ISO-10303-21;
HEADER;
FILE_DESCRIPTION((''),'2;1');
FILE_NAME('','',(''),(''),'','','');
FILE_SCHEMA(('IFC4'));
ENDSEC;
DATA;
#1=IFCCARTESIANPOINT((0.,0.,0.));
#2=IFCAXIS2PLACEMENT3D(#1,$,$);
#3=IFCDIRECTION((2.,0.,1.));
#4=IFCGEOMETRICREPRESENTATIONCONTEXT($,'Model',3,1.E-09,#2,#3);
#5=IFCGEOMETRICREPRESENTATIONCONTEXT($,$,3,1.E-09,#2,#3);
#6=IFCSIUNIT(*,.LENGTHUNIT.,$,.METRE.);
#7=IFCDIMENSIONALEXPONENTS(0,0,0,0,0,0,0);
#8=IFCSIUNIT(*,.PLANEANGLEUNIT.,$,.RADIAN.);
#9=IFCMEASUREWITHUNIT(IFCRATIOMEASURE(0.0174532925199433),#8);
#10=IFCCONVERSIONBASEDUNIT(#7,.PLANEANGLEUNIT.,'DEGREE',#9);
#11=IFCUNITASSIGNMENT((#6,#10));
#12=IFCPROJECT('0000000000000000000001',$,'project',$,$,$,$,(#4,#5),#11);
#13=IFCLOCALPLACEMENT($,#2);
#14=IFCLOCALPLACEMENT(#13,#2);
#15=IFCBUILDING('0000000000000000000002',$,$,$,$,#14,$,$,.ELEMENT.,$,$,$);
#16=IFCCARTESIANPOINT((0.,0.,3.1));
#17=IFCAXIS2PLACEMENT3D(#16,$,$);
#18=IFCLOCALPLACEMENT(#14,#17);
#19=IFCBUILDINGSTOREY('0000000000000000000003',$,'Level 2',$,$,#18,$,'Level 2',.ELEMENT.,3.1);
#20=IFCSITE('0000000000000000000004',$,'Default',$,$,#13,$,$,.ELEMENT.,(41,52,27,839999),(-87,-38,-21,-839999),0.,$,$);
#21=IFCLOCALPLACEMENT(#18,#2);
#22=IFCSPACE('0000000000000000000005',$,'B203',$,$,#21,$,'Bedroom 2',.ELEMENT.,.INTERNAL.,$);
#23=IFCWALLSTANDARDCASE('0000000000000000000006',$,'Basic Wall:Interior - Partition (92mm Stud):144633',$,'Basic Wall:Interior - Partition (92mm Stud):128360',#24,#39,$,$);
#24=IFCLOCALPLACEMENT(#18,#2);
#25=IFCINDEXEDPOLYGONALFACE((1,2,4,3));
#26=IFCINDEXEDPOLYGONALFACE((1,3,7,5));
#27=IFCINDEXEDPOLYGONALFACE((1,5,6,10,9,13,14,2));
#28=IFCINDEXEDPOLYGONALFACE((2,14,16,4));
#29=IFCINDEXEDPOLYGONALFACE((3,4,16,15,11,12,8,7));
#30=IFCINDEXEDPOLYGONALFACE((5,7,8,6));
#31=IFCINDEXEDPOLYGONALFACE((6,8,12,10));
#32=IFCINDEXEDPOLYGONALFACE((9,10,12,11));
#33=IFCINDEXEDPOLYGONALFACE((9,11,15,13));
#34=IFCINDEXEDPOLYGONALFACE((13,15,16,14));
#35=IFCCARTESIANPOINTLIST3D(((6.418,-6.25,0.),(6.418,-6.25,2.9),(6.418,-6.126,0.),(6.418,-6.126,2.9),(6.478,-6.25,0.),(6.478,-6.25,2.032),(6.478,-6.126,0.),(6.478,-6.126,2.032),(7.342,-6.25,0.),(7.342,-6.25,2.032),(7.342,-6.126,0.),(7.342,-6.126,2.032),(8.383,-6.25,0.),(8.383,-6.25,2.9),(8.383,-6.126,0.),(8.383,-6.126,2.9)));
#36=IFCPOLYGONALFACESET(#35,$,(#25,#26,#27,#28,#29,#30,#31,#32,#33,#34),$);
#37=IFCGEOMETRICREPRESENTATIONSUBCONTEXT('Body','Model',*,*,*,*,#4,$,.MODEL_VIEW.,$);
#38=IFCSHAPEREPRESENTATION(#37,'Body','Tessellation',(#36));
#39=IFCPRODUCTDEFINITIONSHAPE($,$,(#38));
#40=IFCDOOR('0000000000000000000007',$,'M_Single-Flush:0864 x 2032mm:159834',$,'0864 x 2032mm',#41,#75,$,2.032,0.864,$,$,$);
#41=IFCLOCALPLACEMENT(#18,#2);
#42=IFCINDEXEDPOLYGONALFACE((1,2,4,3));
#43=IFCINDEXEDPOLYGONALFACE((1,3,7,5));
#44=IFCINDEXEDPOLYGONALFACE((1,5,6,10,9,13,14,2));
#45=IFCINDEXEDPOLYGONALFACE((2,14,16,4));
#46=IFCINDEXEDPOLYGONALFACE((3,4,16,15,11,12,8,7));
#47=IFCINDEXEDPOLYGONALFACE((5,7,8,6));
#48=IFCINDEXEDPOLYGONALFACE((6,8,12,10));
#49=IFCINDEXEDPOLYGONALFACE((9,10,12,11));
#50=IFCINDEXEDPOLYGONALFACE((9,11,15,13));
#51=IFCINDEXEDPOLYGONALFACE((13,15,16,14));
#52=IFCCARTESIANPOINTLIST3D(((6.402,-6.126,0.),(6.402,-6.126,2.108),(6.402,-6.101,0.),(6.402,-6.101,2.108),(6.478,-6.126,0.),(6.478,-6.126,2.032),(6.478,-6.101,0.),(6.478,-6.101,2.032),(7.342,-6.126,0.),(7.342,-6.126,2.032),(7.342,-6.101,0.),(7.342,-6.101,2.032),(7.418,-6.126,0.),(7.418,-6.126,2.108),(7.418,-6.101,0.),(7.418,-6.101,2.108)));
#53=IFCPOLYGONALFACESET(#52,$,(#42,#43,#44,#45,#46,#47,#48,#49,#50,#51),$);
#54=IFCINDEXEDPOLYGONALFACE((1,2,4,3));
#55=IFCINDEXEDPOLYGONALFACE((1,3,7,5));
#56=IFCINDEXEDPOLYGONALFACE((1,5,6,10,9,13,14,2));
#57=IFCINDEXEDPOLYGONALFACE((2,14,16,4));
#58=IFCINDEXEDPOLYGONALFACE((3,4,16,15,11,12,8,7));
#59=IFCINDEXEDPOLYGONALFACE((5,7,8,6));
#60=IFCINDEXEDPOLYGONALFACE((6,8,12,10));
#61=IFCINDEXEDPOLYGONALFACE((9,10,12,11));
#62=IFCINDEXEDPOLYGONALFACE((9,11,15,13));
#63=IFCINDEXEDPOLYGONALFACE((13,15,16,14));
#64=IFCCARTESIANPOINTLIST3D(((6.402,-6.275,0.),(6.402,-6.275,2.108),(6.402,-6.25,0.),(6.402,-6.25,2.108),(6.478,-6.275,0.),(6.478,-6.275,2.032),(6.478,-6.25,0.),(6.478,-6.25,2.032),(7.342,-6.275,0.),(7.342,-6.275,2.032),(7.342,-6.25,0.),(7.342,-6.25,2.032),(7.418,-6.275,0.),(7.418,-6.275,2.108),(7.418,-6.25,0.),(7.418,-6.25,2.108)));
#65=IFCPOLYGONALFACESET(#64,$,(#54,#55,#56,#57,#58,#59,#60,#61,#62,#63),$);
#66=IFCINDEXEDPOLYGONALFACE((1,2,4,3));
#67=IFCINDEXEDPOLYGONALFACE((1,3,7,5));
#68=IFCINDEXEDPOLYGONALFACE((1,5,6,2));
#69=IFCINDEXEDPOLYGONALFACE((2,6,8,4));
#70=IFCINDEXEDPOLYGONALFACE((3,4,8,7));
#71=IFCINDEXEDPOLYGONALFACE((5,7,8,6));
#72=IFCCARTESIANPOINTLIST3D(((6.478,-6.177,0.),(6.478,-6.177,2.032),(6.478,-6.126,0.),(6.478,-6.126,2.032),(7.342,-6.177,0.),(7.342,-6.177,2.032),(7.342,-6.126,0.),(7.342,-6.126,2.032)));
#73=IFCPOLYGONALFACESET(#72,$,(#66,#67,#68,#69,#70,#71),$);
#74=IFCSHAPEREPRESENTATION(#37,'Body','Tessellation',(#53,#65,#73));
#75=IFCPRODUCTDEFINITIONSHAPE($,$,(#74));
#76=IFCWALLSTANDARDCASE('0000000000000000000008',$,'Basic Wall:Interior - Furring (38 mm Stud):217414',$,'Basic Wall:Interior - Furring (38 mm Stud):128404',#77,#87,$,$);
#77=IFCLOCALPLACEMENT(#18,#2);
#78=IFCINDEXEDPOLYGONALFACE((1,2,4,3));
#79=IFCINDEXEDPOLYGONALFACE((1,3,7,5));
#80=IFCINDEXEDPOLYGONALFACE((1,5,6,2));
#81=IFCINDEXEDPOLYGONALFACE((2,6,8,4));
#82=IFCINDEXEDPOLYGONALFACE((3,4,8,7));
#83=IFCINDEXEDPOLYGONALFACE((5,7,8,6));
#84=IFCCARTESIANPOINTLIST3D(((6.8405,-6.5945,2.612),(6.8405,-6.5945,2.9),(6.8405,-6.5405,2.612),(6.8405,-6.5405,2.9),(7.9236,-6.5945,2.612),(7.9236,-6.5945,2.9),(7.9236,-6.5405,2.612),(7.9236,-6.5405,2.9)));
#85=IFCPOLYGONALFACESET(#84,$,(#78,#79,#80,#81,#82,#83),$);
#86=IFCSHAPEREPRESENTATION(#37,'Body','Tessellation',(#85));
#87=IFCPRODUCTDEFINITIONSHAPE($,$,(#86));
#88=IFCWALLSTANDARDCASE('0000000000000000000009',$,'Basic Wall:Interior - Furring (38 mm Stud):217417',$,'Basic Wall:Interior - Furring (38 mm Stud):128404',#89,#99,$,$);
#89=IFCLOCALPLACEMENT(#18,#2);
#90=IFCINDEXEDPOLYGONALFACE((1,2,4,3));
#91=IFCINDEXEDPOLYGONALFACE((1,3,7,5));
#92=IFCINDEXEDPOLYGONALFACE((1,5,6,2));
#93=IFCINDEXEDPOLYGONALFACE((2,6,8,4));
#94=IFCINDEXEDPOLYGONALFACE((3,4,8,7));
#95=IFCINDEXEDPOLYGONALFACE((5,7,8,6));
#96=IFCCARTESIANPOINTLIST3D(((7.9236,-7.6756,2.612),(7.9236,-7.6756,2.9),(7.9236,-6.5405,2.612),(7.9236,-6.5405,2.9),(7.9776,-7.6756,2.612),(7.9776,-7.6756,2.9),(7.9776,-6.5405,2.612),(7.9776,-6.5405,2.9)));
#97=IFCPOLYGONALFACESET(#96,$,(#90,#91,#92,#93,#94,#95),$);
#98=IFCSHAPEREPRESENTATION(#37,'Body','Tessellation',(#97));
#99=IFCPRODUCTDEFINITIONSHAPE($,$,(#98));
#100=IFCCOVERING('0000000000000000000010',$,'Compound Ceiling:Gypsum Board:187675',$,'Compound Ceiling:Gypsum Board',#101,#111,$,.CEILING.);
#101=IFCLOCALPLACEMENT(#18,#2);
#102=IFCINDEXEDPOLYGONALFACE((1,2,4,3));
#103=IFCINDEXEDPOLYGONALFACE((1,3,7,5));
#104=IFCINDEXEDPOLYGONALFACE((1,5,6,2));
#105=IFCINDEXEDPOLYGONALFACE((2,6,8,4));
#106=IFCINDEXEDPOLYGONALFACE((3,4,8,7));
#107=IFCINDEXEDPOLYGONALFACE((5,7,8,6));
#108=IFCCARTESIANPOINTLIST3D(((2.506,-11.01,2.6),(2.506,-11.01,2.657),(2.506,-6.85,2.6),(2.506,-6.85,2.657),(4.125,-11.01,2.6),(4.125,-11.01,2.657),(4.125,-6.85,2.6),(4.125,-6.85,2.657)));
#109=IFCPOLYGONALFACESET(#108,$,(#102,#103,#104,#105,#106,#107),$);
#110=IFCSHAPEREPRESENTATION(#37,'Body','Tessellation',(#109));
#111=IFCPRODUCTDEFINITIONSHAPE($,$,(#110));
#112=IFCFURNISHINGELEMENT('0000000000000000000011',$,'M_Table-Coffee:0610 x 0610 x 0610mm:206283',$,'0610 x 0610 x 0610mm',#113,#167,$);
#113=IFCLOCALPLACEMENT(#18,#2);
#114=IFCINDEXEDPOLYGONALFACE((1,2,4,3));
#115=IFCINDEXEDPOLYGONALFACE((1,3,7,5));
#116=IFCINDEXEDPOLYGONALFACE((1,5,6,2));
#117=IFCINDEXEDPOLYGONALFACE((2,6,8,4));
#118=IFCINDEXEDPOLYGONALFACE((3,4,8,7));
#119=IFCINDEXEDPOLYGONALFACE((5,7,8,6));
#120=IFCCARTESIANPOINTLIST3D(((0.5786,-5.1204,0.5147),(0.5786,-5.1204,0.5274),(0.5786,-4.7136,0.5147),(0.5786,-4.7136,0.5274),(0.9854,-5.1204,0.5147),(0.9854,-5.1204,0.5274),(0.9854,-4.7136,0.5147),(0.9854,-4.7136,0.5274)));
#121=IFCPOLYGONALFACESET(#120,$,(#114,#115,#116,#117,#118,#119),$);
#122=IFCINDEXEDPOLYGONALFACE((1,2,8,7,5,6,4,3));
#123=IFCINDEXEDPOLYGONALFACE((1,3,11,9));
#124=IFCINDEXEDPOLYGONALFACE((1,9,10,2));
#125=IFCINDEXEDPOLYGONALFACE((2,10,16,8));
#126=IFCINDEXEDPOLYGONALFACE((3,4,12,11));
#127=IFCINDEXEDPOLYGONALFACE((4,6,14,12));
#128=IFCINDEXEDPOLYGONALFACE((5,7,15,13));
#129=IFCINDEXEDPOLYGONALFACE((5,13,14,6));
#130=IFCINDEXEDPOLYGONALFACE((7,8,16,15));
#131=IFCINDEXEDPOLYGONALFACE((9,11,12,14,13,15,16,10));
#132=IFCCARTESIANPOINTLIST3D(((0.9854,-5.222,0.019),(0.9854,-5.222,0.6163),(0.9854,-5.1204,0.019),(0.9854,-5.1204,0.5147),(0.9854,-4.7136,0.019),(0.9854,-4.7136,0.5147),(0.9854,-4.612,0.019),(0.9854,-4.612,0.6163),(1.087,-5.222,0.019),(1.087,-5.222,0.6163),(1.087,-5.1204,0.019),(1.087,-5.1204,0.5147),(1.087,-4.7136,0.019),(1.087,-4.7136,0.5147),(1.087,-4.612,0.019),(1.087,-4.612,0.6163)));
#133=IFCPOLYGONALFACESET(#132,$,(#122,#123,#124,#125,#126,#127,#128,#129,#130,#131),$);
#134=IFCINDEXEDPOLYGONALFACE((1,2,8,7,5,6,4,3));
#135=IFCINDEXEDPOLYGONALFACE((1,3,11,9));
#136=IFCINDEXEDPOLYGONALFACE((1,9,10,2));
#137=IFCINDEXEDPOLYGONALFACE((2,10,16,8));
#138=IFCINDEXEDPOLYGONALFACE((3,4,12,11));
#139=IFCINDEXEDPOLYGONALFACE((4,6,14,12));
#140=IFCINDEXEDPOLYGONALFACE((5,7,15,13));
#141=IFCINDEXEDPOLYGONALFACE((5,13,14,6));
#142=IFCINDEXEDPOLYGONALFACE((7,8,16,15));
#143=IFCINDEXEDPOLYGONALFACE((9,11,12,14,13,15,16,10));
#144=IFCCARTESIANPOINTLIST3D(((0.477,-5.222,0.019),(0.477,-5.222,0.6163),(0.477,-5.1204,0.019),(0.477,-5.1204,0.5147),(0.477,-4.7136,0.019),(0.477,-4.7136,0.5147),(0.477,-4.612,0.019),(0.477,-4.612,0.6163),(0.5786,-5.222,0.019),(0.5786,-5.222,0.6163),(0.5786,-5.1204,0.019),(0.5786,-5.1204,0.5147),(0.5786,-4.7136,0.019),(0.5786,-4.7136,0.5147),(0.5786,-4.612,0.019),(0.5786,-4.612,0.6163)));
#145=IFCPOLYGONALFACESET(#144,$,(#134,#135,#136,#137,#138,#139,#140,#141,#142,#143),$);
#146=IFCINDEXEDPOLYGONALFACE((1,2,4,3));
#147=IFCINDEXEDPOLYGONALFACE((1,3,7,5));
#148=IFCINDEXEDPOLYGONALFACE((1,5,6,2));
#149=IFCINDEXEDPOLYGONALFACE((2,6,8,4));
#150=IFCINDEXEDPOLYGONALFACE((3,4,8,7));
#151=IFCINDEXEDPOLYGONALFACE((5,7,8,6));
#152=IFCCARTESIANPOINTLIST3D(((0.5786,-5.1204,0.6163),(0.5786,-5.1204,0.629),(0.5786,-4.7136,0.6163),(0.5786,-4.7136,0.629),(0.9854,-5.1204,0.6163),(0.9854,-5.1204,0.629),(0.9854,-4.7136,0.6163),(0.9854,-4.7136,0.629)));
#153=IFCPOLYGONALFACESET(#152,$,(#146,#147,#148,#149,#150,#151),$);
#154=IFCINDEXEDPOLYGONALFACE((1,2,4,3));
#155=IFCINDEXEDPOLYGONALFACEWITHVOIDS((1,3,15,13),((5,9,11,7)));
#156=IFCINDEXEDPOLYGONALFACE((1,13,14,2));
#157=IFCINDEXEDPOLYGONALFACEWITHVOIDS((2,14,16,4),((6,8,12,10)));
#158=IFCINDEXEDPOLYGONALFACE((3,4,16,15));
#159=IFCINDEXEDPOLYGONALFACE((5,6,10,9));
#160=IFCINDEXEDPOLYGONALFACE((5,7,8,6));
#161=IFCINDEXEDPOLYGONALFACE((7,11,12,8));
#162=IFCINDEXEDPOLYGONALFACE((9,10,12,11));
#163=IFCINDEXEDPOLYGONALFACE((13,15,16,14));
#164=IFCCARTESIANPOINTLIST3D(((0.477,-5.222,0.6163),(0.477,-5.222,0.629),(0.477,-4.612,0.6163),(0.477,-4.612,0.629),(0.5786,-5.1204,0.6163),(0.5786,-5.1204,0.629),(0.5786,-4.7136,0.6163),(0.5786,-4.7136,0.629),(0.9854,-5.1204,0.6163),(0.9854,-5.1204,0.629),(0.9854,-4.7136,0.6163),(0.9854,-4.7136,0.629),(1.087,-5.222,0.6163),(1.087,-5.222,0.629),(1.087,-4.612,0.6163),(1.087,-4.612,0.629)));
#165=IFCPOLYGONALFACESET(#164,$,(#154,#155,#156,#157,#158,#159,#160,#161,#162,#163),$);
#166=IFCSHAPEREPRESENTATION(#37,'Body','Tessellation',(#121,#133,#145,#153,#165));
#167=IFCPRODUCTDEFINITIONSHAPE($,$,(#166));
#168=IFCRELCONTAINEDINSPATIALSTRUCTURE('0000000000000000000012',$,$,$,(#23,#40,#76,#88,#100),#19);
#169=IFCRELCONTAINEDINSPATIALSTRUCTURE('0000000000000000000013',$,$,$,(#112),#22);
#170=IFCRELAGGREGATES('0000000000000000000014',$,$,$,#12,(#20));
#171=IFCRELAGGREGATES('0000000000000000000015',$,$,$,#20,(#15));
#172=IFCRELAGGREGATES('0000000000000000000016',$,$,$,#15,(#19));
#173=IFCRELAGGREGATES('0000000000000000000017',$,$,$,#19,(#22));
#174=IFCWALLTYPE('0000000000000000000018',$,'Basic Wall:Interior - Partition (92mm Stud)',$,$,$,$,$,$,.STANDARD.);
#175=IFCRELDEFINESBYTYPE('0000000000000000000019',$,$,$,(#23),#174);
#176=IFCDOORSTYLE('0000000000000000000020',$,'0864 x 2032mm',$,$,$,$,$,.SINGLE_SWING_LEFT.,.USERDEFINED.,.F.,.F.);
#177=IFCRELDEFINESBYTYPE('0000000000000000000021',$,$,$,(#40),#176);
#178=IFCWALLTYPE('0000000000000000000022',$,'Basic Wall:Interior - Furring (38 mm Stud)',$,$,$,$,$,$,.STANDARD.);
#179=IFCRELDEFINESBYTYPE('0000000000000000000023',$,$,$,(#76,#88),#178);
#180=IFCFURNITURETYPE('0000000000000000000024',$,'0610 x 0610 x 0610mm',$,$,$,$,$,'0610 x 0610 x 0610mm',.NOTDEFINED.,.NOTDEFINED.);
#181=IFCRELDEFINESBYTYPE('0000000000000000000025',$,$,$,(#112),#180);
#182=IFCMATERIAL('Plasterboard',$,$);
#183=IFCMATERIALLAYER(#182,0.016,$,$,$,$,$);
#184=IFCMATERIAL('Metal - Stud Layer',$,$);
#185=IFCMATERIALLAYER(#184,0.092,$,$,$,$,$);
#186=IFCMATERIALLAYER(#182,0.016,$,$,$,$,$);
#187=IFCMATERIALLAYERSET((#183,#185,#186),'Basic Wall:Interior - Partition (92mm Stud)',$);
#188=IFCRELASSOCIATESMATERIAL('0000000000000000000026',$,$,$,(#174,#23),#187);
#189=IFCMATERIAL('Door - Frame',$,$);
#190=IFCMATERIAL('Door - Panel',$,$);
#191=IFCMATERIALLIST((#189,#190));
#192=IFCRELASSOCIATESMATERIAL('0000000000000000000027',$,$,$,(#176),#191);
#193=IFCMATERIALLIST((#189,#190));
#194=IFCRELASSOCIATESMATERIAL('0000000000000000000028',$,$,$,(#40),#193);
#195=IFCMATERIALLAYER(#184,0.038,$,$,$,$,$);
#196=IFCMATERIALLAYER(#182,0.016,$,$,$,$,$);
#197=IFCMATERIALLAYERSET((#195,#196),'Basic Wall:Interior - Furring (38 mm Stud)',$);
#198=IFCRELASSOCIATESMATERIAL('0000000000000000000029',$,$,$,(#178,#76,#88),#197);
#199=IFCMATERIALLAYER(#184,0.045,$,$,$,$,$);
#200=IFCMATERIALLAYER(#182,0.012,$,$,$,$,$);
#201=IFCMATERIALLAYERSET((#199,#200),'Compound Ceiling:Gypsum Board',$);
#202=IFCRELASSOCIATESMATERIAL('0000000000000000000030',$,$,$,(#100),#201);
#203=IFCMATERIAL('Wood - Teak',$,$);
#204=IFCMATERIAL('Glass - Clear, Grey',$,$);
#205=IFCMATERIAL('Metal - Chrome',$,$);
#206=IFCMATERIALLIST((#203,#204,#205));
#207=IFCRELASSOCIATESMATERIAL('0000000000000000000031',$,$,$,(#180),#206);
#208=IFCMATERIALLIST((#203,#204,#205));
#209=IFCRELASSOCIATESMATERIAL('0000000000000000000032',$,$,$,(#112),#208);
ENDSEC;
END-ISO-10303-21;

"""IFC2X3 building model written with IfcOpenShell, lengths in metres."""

from ifc_helpers import new_model, entity, si_unit, converted_unit, direction, frame, frame_2d, origin, origin_2d_with_axis, place, context, subcontext, project, spatial, polyline, rectangle, outline, extrude, source, transform, mapped, material, material_list, layer, layer_set, layer_usage, type_object, type_shapes, element, fill, save


model = new_model("IFC2X3")

# Units and contexts
model_context = context("Model", 3, precision=1e-09, world=origin(), true_north=direction((2.0, 0.0, 1.0)))
context_of_model = context(None, 3, precision=1e-09, world=origin(), true_north=direction((2.0, 0.0, 1.0)))
body_context = subcontext(model_context, "Body", "Model", "MODEL_VIEW")
ifc_project = project(units=[si_unit("LENGTHUNIT", "METRE"), converted_unit("PLANEANGLEUNIT", "DEGREE", entity("IfcRatioMeasure", 0.0174532925199433), si_unit("PLANEANGLEUNIT", "RADIAN"), dimensions=[0, 0, 0, 0, 0, 0, 0])], contexts=[model_context, context_of_model])

# Site, building, storey
site_placement = place(None, origin())
site = spatial("IfcSite", under=ifc_project, at=site_placement, Name="Default", CompositionType="ELEMENT", RefLatitude=(41, 52, 27, 839999), RefLongitude=(-87, -38, -21, -839999), RefElevation=0.0)
building_placement = place(site_placement, origin())
building = spatial("IfcBuilding", under=site, at=building_placement, CompositionType="ELEMENT")
storey_placement = place(building_placement, frame((0.0, 0.0, 3.1)))
storey = spatial("IfcBuildingStorey", under=building, at=storey_placement, Name="Level 2", LongName="Level 2", CompositionType="ELEMENT", Elevation=3.1)

# Shared definitions
ifc_material_1 = material(Name="Metal - Stud Layer")
ifc_material_2 = material(Name="Plasterboard")

# Wall, opening, door
ifc_layer_1 = layer(ifc_material_2, 0.016)
ifc_layer_2 = layer(ifc_material_1, 0.092)
ifc_layer_3 = layer(ifc_material_2, 0.016)
ifc_layer_set_1 = layer_set([ifc_layer_1, ifc_layer_2, ifc_layer_3], Name="Basic Wall:Interior - Partition (92mm Stud)")
wall_type_1 = type_object("IfcWallType", Name="Basic Wall:Interior - Partition (92mm Stud)", PredefinedType="STANDARD", material=ifc_layer_set_1)
ifc_material_3 = material(Name="Door - Frame")
ifc_material_4 = material(Name="Door - Panel")
ifc_layer_usage_1 = layer_usage(ifc_layer_set_1, "AXIS2", "NEGATIVE", 0.062)
wall_1_placement = place(storey_placement, frame((6.418, -6.188, 0.0)))
wall_1 = element("IfcWallStandardCase", 1, at=wall_1_placement, inside=storey, type_object=wall_type_1, material=ifc_layer_usage_1, Name="Basic Wall:Interior - Partition (92mm Stud):144633", ObjectType="Basic Wall:Interior - Partition (92mm Stud):128360", context=body_context, shape_type="SweptSolid", body=[
    extrude(rectangle(XDim=1.965, YDim=0.124, at=frame_2d((0.9825, 0.0), x_axis=(-1.0, 0.0))), origin(), (0.0, 0.0, 1.0), 2.9),
])
opening_1_placement = place(wall_1_placement, frame((0.06, -0.062, 0.0)))
opening_1 = element("IfcOpeningElement", 2, at=opening_1_placement, cuts=wall_1, ObjectType="Opening", context=body_context, shape_type="SweptSolid", body=[
    extrude(rectangle(XDim=0.864, YDim=2.032, at=frame_2d((1.016, 0.432), x_axis=(0.0, -1.0))), frame((0.0, 0.0, 0.0), z_axis=(0.0, 1.0, 0.0), x_axis=(0.0, 0.0, 1.0)), (0.0, 0.0, 1.0), 0.124),
])
ifc_material_list_1 = material_list([ifc_material_3, ifc_material_4])
ifc_material_list_2 = material_list([ifc_material_3, ifc_material_4])
door_style_1 = type_object("IfcDoorStyle", Name="0864 x 2032mm", ConstructionType="USERDEFINED", OperationType="SINGLE_SWING_LEFT", ParameterTakesPrecedence=False, Sizeable=False, material=ifc_material_list_2)
shared_shape_1 = source(origin(), body_context, "Body", "SweptSolid", [
    extrude(outline(polyline([(-0.508, -1.073), (0.508, -1.073), (0.508, 1.035), (0.432, 1.035), (0.432, -0.997), (-0.432, -0.997), (-0.432, 1.035), (-0.508, 1.035), (-0.508, -1.073)])), frame((0.432, 0.149, 1.035), z_axis=(0.0, -1.0, 0.0), x_axis=(-1.0, 0.0, 0.0)), (0.0, 0.0, 1.0), 0.025),
    extrude(outline(polyline([(-1.073, -0.508), (1.035, -0.508), (1.035, -0.432), (-0.997, -0.432), (-0.997, 0.432), (1.035, 0.432), (1.035, 0.508), (-1.073, 0.508), (-1.073, -0.508)])), frame((0.432, 0.0, 1.035), z_axis=(0.0, -1.0, 0.0), x_axis=(0.0, 0.0, -1.0)), (0.0, 0.0, 1.0), 0.025),
    extrude(rectangle(XDim=0.864, YDim=0.051, at=frame_2d((0.0, 0.0), x_axis=(1.0, 0.0))), frame((0.432, 0.0985, 0.0)), (0.0, 0.0, 1.0), 2.032),
])
type_shapes(door_style_1, [shared_shape_1])
door_1_placement = place(opening_1_placement, origin())
door_1 = element("IfcDoor", 3, at=door_1_placement, inside=storey, type_object=door_style_1, material=ifc_material_list_1, Name="M_Single-Flush:0864 x 2032mm:159834", ObjectType="0864 x 2032mm", OverallHeight=2.032, OverallWidth=0.864, context=body_context, shape_type="MappedRepresentation", body=[
    mapped(shared_shape_1, transform((0.0, 0.0, 0.0), scale=1.0)),
])
fill(opening_1, door_1)

# Walls
ifc_layer_4 = layer(ifc_material_1, 0.038)
ifc_layer_5 = layer(ifc_material_2, 0.016)
ifc_layer_set_2 = layer_set([ifc_layer_4, ifc_layer_5], Name="Basic Wall:Interior - Furring (38 mm Stud)")
ifc_layer_usage_2 = layer_usage(ifc_layer_set_2, "AXIS2", "NEGATIVE", 0.027)
wall_type_2 = type_object("IfcWallType", Name="Basic Wall:Interior - Furring (38 mm Stud)", PredefinedType="STANDARD", material=ifc_layer_set_2)
wall_2_placement = place(storey_placement, frame((6.8405, -6.5675, 2.612)))
element("IfcWallStandardCase", 4, at=wall_2_placement, inside=storey, type_object=wall_type_2, material=ifc_layer_usage_2, Name="Basic Wall:Interior - Furring (38 mm Stud):217414", ObjectType="Basic Wall:Interior - Furring (38 mm Stud):128404", context=body_context, shape_type="SweptSolid", body=[
    extrude(rectangle(XDim=1.0831, YDim=0.054, at=frame_2d((0.5415, 0.0), x_axis=(-1.0, 0.0))), origin(), (0.0, 0.0, 1.0), 0.288),
])
ifc_layer_usage_3 = layer_usage(ifc_layer_set_2, "AXIS2", "NEGATIVE", 0.027)
wall_3_placement = place(storey_placement, frame((7.9506, -6.5405, 2.612), z_axis=(0.0, 0.0, 1.0), x_axis=(0.0, -1.0, 0.0)))
element("IfcWallStandardCase", 5, at=wall_3_placement, inside=storey, type_object=wall_type_2, material=ifc_layer_usage_3, Name="Basic Wall:Interior - Furring (38 mm Stud):217417", ObjectType="Basic Wall:Interior - Furring (38 mm Stud):128404", context=body_context, shape_type="SweptSolid", body=[
    extrude(rectangle(XDim=1.1351, YDim=0.054, at=frame_2d((0.5675, 0.0), x_axis=(-1.0, 0.0))), origin(), (0.0, 0.0, 1.0), 0.288),
])

# Covering
ifc_layer_6 = layer(ifc_material_1, 0.045)
ifc_layer_7 = layer(ifc_material_2, 0.012)
ifc_layer_set_3 = layer_set([ifc_layer_6, ifc_layer_7], Name="Compound Ceiling:Gypsum Board")
ifc_layer_usage_4 = layer_usage(ifc_layer_set_3, "AXIS3", "NEGATIVE", 0.0)
covering_1_placement = place(storey_placement, origin())
element("IfcCovering", 6, at=covering_1_placement, inside=storey, material=ifc_layer_usage_4, Name="Compound Ceiling:Gypsum Board:187675", ObjectType="Compound Ceiling:Gypsum Board", PredefinedType="CEILING", context=body_context, shape_type="SweptSolid", body=[
    extrude(rectangle(XDim=1.619, YDim=4.16, at=frame_2d((0.0, 0.0), x_axis=(1.0, 0.0))), frame((3.3155, -8.93, 2.6), z_axis=(0.0, 0.0, 1.0), x_axis=(-1.0, 0.0, 0.0)), (0.0, 0.0, 1.0), 0.057),
])

# Shared definitions
space_1_placement = place(storey_placement, origin())
space_1 = spatial("IfcSpace", under=storey, at=space_1_placement, Name="B203", LongName="Bedroom 2", CompositionType="ELEMENT", InteriorOrExteriorSpace="INTERNAL")

# Furnishing element
ifc_material_5 = material(Name="Wood - Teak")
ifc_material_6 = material(Name="Glass - Clear, Grey")
ifc_material_7 = material(Name="Metal - Chrome")
ifc_material_list_3 = material_list([ifc_material_5, ifc_material_6, ifc_material_7])
ifc_material_list_4 = material_list([ifc_material_5, ifc_material_6, ifc_material_7])
furniture_type_1 = type_object("IfcFurnitureType", Name="0610 x 0610 x 0610mm", ElementType="0610 x 0610 x 0610mm", AssemblyPlace="NOTDEFINED", material=ifc_material_list_4)
shared_shape_2 = source(origin(), body_context, "Body", "SweptSolid", [
    extrude(rectangle(XDim=0.4068, YDim=0.4068, at=origin_2d_with_axis()), frame((0.0183, 0.0952, 0.4957), z_axis=(0.0, 0.0, 1.0), x_axis=(-1.0, 0.0, 0.0)), (0.0, 0.0, 1.0), 0.0127),
    extrude(outline(polyline([(-0.2732, -0.305), (0.324, -0.305), (0.324, 0.305), (-0.2732, 0.305), (-0.2732, 0.2034), (0.2225, 0.2034), (0.2225, -0.2034), (-0.2732, -0.2034), (-0.2732, -0.305)])), frame((0.2217, 0.0952, 0.2732), z_axis=(1.0, 0.0, 0.0), x_axis=(0.0, 0.0, 1.0)), (0.0, 0.0, 1.0), 0.1016),
    extrude(outline(polyline([(-0.305, -0.3241), (0.305, -0.3241), (0.305, 0.2733), (0.2034, 0.2733), (0.2034, -0.2224), (-0.2034, -0.2224), (-0.2034, 0.2733), (-0.305, 0.2733), (-0.305, -0.3241)])), frame((-0.2867, 0.0952, 0.2733), z_axis=(1.0, 0.0, 0.0), x_axis=(0.0, -1.0, 0.0)), (0.0, 0.0, 1.0), 0.1016),
    extrude(rectangle(XDim=0.4068, YDim=0.4068, at=origin_2d_with_axis()), frame((0.0183, 0.0952, 0.5973), z_axis=(0.0, 0.0, 1.0), x_axis=(-1.0, 0.0, 0.0)), (0.0, 0.0, 1.0), 0.0127),
    extrude(outline(polyline([(-0.305, -0.305), (0.305, -0.305), (0.305, 0.305), (-0.305, 0.305), (-0.305, -0.305)]), holes=[polyline([(-0.2034, -0.2034), (-0.2034, 0.2034), (0.2034, 0.2034), (0.2034, -0.2034), (-0.2034, -0.2034)])]), frame((0.0183, 0.0952, 0.5973), z_axis=(0.0, 0.0, 1.0), x_axis=(-1.0, 0.0, 0.0)), (0.0, 0.0, 1.0), 0.0127),
])
type_shapes(furniture_type_1, [shared_shape_2])
furnishing_1_placement = place(space_1_placement, frame((0.7637, -5.0122, 0.019)))
element("IfcFurnishingElement", 7, at=furnishing_1_placement, inside=space_1, type_object=furniture_type_1, material=ifc_material_list_3, Name="M_Table-Coffee:0610 x 0610 x 0610mm:206283", ObjectType="0610 x 0610 x 0610mm", context=body_context, shape_type="MappedRepresentation", body=[
    mapped(shared_shape_2, transform((0.0, 0.0, 0.0), scale=1.0)),
])

save(model, "model.ifc")
